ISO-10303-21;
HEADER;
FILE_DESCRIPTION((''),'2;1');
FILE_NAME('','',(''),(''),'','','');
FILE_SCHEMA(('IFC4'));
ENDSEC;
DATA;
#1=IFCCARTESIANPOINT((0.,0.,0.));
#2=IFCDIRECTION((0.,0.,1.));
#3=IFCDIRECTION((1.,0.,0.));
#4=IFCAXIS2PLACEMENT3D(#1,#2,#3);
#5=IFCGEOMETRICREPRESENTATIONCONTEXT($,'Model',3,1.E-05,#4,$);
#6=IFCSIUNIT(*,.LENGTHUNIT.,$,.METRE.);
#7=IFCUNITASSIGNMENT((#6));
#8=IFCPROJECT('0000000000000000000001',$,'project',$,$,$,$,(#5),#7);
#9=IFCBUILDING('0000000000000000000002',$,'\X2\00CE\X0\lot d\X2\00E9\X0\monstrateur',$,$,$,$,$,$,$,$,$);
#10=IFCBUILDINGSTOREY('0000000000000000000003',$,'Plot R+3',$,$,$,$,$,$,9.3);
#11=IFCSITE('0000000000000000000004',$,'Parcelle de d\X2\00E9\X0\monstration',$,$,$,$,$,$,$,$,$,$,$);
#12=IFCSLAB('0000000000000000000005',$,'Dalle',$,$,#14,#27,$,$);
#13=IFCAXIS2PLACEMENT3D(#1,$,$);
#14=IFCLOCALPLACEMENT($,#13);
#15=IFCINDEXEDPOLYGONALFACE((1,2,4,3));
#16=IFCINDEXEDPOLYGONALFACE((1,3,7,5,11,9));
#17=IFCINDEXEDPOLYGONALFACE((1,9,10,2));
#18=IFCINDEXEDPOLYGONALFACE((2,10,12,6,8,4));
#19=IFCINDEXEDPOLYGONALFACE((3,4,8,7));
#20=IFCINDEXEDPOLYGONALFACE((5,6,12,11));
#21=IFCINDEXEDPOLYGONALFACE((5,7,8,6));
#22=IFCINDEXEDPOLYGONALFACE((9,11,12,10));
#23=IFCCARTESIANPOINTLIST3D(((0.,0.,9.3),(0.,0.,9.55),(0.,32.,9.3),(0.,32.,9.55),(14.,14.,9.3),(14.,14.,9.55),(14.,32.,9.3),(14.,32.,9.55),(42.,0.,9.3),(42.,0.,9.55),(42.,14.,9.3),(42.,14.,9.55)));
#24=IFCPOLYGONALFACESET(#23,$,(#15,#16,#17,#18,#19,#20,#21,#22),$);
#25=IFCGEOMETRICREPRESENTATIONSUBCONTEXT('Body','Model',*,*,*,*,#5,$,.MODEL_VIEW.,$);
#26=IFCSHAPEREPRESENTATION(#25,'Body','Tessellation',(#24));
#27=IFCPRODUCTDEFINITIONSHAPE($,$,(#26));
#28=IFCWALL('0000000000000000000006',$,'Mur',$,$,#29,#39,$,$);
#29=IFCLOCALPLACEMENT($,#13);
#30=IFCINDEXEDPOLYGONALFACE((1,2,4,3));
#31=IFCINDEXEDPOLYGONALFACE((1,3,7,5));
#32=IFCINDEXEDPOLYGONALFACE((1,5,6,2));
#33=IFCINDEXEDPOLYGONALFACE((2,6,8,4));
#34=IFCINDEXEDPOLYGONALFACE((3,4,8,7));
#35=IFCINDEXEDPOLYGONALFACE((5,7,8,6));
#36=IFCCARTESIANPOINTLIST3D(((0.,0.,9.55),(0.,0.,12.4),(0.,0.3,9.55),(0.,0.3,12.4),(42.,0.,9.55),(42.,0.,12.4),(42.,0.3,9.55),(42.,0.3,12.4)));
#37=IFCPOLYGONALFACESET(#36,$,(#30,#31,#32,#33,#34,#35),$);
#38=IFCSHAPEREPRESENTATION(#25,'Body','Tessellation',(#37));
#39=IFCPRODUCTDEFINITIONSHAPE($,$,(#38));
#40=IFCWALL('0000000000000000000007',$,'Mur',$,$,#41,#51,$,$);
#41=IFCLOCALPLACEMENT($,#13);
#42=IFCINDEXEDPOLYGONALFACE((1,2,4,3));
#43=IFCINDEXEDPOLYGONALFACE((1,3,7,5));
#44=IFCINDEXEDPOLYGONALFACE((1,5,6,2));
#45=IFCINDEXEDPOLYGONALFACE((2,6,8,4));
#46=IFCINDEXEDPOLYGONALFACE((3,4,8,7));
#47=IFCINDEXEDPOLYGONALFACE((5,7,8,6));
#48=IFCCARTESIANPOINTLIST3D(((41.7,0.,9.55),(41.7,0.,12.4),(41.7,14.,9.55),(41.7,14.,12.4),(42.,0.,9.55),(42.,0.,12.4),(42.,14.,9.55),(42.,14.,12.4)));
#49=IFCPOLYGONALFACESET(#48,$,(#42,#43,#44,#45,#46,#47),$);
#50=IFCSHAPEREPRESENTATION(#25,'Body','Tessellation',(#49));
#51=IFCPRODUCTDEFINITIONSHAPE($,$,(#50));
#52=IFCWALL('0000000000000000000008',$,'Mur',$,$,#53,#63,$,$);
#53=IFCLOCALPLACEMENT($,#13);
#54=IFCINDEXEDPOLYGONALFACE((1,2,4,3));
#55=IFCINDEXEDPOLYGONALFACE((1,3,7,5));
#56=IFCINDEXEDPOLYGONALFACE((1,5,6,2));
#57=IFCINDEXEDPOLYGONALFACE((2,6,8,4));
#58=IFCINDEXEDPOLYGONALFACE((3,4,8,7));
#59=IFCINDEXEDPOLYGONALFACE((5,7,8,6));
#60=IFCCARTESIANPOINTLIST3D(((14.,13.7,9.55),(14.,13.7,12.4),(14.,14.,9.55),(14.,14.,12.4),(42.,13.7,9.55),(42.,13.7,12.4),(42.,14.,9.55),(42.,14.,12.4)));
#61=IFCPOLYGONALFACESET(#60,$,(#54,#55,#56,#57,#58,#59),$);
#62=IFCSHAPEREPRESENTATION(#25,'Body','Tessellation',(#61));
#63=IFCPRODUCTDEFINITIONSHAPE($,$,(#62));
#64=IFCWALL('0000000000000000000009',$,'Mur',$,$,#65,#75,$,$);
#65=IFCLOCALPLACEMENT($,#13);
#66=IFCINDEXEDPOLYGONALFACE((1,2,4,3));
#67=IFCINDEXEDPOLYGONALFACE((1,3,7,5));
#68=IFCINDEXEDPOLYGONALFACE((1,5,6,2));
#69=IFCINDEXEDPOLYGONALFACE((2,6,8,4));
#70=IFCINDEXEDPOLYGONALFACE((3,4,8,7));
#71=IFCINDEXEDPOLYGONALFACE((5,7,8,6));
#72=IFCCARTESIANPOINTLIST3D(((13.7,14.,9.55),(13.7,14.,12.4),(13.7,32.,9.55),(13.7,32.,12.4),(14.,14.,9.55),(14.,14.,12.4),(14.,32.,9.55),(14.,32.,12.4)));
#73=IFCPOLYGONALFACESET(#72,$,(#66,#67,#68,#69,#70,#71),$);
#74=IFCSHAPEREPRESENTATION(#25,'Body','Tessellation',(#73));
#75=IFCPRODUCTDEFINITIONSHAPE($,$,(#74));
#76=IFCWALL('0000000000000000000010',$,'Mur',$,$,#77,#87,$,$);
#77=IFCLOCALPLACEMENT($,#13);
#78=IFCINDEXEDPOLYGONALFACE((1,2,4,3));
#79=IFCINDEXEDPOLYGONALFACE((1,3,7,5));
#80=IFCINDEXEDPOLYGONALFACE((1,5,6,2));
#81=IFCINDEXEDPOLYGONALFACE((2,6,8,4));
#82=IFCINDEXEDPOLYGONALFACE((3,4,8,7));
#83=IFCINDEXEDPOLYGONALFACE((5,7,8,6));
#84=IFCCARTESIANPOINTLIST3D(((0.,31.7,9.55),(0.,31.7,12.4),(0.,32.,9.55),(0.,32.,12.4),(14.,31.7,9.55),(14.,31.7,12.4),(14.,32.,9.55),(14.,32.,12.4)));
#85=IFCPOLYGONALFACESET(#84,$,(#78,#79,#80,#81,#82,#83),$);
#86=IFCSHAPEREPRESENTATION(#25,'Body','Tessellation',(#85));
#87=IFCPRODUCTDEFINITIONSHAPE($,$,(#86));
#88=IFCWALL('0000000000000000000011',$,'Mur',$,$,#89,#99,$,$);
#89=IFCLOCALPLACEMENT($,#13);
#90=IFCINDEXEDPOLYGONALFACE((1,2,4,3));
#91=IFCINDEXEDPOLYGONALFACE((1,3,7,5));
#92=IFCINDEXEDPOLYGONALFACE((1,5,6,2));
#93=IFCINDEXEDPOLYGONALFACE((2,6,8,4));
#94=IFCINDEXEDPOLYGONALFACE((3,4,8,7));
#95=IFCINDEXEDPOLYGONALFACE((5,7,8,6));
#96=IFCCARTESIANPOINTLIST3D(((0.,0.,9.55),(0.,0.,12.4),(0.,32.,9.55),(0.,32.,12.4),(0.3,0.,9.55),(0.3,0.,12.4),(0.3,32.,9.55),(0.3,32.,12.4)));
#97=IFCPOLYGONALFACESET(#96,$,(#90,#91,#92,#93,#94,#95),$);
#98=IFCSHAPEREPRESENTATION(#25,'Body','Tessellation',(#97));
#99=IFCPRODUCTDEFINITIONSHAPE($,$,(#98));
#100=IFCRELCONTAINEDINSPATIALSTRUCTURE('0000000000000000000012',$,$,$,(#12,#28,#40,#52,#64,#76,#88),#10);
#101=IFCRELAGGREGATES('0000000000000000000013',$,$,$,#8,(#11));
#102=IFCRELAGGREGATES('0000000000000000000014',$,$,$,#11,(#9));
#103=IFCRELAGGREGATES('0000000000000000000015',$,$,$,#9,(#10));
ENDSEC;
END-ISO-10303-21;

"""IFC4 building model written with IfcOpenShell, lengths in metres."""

from ifc_helpers import new_model, si_unit, frame, origin_with_axes, place, context, subcontext, project, spatial, indexed_curve, outline, extrude, element, save


model = new_model("IFC4")

# Units and contexts
model_context = context("Model", 3, precision=1e-05, world=origin_with_axes())
body_context = subcontext(model_context, "Body", "Model", "MODEL_VIEW")
ifc_project = project(units=[si_unit("LENGTHUNIT", "METRE")], contexts=[model_context])

# Site, building, storey
site = spatial("IfcSite", under=ifc_project, Name="Parcelle de démonstration")
building = spatial("IfcBuilding", under=site, Name="Îlot démonstrateur")
storey = spatial("IfcBuildingStorey", under=building, Name="Plot R+3", Elevation=9.3)

# Slab
slab_placement = place(None, frame((0.0, 0.0, 9.3), z_axis=(0.0, 0.0, 1.0), x_axis=(1.0, 0.0, 0.0)))
element("IfcSlab", 1, at=slab_placement, inside=storey, Name="Dalle", context=body_context, shape_type="SweptSolid", body=[
    extrude(outline(indexed_curve([(0.0, 0.0), (42.0, 0.0), (42.0, 14.0), (14.0, 14.0), (14.0, 32.0), (0.0, 32.0)])), None, (0.0, 0.0, 1.0), 0.25),
])

# Walls
wall_1_placement = place(None, frame((0.0, 0.0, 9.55), z_axis=(0.0, 0.0, 1.0), x_axis=(1.0, 0.0, 0.0)))
element("IfcWall", 2, at=wall_1_placement, inside=storey, Name="Mur", context=body_context, shape_type="SweptSolid", body=[
    extrude(outline(indexed_curve([(0.0, 0.0), (0.0, 0.3), (42.0, 0.3), (42.0, 0.0), (0.0, 0.0)], self_intersect=False)), origin_with_axes(), (0.0, 0.0, 1.0), 2.85),
])
wall_2_placement = place(None, frame((42.0, 0.0, 9.55), z_axis=(0.0, 0.0, 1.0), x_axis=(0.0, 1.0, 0.0)))
element("IfcWall", 3, at=wall_2_placement, inside=storey, Name="Mur", context=body_context, shape_type="SweptSolid", body=[
    extrude(outline(indexed_curve([(0.0, 0.0), (0.0, 0.3), (14.0, 0.3), (14.0, 0.0), (0.0, 0.0)], self_intersect=False)), origin_with_axes(), (0.0, 0.0, 1.0), 2.85),
])
wall_3_placement = place(None, frame((42.0, 14.0, 9.55), z_axis=(0.0, 0.0, 1.0), x_axis=(-1.0, 0.0, 0.0)))
element("IfcWall", 4, at=wall_3_placement, inside=storey, Name="Mur", context=body_context, shape_type="SweptSolid", body=[
    extrude(outline(indexed_curve([(0.0, 0.0), (0.0, 0.3), (28.0, 0.3), (28.0, 0.0), (0.0, 0.0)], self_intersect=False)), origin_with_axes(), (0.0, 0.0, 1.0), 2.85),
])
wall_4_placement = place(None, frame((14.0, 14.0, 9.55), z_axis=(0.0, 0.0, 1.0), x_axis=(0.0, 1.0, 0.0)))
element("IfcWall", 5, at=wall_4_placement, inside=storey, Name="Mur", context=body_context, shape_type="SweptSolid", body=[
    extrude(outline(indexed_curve([(0.0, 0.0), (0.0, 0.3), (18.0, 0.3), (18.0, 0.0), (0.0, 0.0)], self_intersect=False)), origin_with_axes(), (0.0, 0.0, 1.0), 2.85),
])
wall_5_placement = place(None, frame((14.0, 32.0, 9.55), z_axis=(0.0, 0.0, 1.0), x_axis=(-1.0, 0.0, 0.0)))
element("IfcWall", 6, at=wall_5_placement, inside=storey, Name="Mur", context=body_context, shape_type="SweptSolid", body=[
    extrude(outline(indexed_curve([(0.0, 0.0), (0.0, 0.3), (14.0, 0.3), (14.0, 0.0), (0.0, 0.0)], self_intersect=False)), origin_with_axes(), (0.0, 0.0, 1.0), 2.85),
])
wall_6_placement = place(None, frame((0.0, 32.0, 9.55), z_axis=(0.0, 0.0, 1.0), x_axis=(0.0, -1.0, 0.0)))
element("IfcWall", 7, at=wall_6_placement, inside=storey, Name="Mur", context=body_context, shape_type="SweptSolid", body=[
    extrude(outline(indexed_curve([(0.0, 0.0), (0.0, 0.3), (32.0, 0.3), (32.0, 0.0), (0.0, 0.0)], self_intersect=False)), origin_with_axes(), (0.0, 0.0, 1.0), 2.85),
])

save(model, "model.ifc")
